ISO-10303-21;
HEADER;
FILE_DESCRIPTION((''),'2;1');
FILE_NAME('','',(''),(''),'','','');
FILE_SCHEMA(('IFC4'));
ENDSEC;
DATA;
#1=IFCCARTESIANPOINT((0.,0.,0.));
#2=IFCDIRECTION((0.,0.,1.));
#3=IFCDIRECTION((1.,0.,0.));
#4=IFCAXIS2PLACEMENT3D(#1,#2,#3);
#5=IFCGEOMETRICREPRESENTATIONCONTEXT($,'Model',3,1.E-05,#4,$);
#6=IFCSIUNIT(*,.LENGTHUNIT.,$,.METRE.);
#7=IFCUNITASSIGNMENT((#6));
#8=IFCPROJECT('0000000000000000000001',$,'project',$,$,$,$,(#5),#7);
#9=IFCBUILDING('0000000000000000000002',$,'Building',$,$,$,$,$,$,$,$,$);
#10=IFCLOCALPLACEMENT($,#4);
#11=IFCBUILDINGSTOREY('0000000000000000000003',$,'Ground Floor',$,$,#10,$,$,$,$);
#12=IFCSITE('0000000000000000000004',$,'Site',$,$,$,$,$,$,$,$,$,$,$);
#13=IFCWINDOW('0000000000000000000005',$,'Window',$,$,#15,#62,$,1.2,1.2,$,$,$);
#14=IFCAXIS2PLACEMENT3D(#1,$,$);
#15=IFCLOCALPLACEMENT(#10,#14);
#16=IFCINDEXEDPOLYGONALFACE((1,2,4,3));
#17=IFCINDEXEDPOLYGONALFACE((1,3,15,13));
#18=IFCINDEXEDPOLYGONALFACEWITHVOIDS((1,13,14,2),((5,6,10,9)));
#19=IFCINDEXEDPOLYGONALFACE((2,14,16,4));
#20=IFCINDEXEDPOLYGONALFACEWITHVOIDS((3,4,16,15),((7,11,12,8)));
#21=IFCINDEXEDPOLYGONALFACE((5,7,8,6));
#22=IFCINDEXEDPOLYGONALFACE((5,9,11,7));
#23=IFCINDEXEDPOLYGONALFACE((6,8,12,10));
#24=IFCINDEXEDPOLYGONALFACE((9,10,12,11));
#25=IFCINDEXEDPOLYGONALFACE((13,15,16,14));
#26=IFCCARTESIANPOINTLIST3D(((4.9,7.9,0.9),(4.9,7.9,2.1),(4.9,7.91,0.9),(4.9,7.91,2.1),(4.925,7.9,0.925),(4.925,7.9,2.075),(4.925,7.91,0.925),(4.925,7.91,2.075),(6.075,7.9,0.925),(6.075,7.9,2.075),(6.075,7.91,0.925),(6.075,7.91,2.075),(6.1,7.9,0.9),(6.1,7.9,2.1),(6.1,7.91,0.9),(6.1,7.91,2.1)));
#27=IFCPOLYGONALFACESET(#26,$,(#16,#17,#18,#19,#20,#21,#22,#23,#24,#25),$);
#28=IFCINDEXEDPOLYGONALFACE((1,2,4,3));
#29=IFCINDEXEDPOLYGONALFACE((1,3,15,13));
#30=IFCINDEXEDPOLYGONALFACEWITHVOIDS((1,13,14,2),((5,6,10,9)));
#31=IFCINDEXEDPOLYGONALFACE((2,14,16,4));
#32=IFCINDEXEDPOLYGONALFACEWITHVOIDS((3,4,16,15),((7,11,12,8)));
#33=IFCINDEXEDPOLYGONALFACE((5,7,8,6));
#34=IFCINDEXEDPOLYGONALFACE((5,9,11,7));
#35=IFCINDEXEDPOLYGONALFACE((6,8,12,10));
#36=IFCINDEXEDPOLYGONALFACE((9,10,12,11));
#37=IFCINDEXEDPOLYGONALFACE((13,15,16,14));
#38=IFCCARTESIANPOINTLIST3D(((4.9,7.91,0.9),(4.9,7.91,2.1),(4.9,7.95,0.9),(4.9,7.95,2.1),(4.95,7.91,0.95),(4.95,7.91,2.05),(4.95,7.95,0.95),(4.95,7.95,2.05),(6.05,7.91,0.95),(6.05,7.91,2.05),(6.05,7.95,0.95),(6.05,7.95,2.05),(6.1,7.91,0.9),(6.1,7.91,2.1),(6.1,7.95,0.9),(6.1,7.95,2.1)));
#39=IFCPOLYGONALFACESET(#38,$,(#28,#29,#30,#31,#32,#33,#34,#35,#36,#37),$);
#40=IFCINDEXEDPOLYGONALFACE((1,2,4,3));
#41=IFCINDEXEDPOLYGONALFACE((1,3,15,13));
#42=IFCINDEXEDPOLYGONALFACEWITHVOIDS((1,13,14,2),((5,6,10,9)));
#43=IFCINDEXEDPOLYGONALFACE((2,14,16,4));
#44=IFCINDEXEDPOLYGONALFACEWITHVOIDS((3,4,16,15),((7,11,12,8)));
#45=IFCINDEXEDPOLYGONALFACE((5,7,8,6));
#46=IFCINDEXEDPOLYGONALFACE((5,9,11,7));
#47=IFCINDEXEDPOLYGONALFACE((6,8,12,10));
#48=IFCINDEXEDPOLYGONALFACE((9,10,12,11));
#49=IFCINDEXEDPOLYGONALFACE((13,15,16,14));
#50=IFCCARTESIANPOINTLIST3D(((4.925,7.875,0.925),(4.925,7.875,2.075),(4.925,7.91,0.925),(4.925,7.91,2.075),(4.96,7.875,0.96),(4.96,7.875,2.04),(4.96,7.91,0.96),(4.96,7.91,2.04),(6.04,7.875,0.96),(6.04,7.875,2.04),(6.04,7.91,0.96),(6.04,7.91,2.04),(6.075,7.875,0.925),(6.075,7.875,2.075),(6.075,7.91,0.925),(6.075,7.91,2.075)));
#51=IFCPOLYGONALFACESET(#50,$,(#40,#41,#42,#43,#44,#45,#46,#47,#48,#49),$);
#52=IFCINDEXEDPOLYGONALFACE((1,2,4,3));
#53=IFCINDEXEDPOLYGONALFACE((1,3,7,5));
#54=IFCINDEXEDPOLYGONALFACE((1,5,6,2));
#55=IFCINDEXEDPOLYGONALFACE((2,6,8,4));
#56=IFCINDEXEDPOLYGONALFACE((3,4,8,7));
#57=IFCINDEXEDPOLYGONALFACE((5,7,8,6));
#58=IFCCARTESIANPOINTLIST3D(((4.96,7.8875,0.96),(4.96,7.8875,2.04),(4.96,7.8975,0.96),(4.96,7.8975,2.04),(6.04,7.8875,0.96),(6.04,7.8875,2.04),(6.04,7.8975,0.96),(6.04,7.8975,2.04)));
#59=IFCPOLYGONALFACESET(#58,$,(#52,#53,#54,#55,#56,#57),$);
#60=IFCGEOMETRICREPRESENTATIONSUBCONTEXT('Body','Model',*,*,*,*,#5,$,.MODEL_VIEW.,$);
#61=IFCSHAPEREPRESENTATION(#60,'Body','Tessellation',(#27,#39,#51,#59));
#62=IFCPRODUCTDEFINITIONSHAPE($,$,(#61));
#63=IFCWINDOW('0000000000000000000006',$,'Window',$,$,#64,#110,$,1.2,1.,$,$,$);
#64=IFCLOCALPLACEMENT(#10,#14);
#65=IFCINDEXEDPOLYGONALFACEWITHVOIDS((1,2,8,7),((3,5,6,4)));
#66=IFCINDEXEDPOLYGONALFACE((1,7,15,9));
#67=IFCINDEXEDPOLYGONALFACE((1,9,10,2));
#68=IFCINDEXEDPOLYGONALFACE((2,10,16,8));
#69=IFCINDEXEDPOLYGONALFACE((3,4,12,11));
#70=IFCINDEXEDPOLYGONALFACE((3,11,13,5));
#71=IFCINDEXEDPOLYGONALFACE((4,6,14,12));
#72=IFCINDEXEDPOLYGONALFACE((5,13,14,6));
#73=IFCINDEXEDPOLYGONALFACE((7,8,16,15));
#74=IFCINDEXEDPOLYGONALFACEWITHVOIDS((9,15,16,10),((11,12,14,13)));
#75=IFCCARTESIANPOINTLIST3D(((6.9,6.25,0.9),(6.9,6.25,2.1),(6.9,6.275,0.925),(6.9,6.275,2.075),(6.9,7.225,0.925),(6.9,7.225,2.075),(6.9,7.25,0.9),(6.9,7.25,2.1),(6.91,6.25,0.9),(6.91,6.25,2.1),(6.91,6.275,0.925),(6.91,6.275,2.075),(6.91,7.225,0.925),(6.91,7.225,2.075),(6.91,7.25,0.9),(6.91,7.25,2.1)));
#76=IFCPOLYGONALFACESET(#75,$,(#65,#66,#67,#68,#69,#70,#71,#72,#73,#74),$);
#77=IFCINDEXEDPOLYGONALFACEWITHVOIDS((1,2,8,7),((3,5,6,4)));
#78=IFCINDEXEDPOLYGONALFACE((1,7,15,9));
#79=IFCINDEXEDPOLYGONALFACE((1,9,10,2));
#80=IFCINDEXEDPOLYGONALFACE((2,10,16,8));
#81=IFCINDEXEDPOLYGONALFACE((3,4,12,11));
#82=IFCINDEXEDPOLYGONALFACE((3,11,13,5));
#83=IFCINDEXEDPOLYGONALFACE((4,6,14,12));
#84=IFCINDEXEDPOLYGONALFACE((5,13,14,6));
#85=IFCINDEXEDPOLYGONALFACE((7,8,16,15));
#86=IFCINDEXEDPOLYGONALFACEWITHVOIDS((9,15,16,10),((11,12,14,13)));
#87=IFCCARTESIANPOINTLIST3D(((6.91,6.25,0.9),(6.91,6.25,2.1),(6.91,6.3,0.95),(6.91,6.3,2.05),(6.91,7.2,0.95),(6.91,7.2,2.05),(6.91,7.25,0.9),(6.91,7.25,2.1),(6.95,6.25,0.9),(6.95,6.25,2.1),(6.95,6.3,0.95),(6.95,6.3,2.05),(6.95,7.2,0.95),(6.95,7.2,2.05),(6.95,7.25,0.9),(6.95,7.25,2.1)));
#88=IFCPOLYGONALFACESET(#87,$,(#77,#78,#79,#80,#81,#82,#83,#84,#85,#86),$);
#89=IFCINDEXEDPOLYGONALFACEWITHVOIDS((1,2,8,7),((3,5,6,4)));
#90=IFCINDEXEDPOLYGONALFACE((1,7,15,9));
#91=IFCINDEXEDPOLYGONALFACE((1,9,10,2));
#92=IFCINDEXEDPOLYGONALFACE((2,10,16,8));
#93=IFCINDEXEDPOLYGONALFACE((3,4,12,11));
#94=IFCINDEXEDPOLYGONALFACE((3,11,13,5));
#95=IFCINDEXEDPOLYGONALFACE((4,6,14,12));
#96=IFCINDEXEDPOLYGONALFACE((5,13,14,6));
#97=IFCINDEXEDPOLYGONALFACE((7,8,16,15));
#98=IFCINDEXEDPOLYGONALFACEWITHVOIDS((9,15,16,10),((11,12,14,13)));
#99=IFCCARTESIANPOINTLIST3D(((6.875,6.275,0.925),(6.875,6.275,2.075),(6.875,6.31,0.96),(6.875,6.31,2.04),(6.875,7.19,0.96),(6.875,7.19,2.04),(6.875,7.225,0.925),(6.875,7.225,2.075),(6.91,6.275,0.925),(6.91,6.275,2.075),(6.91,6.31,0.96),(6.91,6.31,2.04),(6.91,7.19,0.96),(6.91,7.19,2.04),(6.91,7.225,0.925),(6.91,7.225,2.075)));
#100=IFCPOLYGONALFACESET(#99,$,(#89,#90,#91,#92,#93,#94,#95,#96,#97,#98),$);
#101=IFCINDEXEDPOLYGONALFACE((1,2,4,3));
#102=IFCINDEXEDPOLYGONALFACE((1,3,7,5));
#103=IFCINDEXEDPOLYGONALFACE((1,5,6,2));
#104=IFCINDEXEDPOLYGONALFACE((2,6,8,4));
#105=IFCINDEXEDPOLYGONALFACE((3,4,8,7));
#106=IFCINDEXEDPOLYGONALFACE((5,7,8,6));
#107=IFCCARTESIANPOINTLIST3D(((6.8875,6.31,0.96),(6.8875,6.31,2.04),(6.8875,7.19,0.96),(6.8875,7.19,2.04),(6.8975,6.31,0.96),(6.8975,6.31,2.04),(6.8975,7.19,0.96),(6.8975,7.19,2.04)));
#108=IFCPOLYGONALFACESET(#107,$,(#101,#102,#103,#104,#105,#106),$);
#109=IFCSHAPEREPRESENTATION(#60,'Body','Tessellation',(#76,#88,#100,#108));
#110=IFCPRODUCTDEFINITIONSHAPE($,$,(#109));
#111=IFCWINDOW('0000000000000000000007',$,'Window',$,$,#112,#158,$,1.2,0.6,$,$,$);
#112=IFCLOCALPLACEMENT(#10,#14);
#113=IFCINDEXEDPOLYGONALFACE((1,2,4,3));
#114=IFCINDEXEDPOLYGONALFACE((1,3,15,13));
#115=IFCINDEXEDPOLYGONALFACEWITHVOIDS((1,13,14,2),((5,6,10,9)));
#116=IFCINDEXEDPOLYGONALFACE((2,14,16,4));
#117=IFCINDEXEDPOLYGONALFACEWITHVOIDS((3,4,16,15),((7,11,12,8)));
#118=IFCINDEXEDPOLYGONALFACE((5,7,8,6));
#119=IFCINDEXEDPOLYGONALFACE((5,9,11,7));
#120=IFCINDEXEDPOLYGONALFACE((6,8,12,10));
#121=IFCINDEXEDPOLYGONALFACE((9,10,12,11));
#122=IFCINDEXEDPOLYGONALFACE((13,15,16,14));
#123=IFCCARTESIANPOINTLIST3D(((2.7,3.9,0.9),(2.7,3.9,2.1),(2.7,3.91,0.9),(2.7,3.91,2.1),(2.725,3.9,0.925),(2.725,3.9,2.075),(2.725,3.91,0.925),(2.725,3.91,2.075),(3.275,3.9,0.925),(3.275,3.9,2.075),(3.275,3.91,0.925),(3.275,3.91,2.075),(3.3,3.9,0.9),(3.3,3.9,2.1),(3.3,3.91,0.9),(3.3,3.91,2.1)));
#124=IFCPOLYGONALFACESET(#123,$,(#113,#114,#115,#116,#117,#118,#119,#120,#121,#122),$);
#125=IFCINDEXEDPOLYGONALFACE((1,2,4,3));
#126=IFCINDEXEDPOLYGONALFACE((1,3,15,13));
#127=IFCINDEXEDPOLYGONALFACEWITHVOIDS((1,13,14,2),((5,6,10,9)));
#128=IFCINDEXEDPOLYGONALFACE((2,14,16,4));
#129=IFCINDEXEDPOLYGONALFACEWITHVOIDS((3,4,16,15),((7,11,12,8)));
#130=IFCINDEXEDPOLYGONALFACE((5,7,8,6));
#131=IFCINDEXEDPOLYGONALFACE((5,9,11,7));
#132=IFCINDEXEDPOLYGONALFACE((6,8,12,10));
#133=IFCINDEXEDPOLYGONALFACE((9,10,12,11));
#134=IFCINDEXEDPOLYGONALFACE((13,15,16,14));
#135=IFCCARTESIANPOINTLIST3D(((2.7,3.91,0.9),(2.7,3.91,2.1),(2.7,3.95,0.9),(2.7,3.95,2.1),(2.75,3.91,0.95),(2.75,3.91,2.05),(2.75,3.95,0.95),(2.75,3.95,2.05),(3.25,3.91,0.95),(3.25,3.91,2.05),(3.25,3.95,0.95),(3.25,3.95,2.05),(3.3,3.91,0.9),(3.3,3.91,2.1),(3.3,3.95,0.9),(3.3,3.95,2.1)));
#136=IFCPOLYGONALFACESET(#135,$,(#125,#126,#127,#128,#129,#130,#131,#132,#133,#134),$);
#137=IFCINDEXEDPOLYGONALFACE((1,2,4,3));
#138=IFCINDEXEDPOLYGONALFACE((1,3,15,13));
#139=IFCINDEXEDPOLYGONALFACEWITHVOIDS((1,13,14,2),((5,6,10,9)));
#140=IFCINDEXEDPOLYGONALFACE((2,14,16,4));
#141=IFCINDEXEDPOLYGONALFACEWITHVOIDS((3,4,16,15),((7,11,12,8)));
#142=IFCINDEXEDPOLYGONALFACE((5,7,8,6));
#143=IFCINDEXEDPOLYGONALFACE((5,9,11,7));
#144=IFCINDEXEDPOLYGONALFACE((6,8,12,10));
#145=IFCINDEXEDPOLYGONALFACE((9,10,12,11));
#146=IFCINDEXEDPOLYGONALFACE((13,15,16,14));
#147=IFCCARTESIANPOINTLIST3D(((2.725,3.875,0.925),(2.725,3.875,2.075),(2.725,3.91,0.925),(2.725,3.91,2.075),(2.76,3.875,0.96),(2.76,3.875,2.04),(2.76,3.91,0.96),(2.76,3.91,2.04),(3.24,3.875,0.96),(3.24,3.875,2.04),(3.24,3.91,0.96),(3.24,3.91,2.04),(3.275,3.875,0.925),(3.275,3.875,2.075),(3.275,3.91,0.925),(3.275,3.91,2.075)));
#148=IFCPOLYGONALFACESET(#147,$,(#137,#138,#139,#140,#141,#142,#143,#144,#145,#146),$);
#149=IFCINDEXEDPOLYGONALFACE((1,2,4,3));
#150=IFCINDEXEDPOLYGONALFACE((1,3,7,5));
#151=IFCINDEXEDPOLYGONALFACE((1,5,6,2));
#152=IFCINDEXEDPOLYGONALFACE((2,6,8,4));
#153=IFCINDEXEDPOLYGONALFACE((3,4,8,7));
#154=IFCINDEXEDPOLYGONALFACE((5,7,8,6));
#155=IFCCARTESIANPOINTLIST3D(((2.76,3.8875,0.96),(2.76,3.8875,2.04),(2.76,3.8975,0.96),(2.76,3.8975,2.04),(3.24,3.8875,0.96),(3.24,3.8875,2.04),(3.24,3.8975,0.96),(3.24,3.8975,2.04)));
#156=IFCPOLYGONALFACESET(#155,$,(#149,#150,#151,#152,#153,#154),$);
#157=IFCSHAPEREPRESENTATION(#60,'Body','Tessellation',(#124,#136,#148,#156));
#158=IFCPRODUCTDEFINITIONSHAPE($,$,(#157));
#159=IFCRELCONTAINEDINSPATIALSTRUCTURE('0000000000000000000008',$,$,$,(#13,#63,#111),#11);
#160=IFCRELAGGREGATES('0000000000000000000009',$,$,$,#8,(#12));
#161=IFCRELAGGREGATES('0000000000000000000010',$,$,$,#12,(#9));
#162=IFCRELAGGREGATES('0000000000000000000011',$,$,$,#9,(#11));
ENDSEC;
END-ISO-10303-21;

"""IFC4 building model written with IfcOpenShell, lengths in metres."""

from ifc_helpers import new_model, si_unit, frame, origin_with_axes, place, context, subcontext, project, spatial, line, indexed_curve, outline, extrude, element, save


model = new_model("IFC4")

# Units and contexts
model_context = context("Model", 3, precision=1e-05, world=origin_with_axes())
body_context = subcontext(model_context, "Body", "Model", "MODEL_VIEW")
ifc_project = project(units=[si_unit("LENGTHUNIT", "METRE")], contexts=[model_context])

# Site, building, storey
site = spatial("IfcSite", under=ifc_project, Name="Site")
building = spatial("IfcBuilding", under=site, Name="Building")
storey_placement = place(None, origin_with_axes())
storey = spatial("IfcBuildingStorey", under=building, at=storey_placement, Name="Ground Floor")

# Windows
window_1_placement = place(storey_placement, frame((6.1, 8.0, 0.9), z_axis=(0.0, 0.0, 1.0), x_axis=(-1.0, 0.0, 0.0)))
element("IfcWindow", 1, at=window_1_placement, inside=storey, Name="Window", OverallHeight=1.2, OverallWidth=1.2, context=body_context, shape_type="SweptSolid", body=[
    extrude(outline(indexed_curve([(0.0, 0.0), (1.2, 0.0), (1.2, 1.2), (0.0, 1.2)], segments=[line(1, 2, 3, 4, 1)]), holes=[indexed_curve([(0.025, 0.025), (1.175, 0.025), (1.175, 1.175), (0.025, 1.175)], segments=[line(1, 2, 3, 4, 1)])]), frame((0.0, 0.09, 0.0), z_axis=(0.0, -1.0, 0.0), x_axis=(1.0, 0.0, 0.0)), (0.0, 0.0, -1.0), 0.01),
    extrude(outline(indexed_curve([(0.0, 0.0), (1.2, 0.0), (1.2, 1.2), (0.0, 1.2)], segments=[line(1, 2, 3, 4, 1)]), holes=[indexed_curve([(0.05, 0.05), (1.15, 0.05), (1.15, 1.15), (0.05, 1.15)], segments=[line(1, 2, 3, 4, 1)])]), frame((0.0, 0.05, 0.0), z_axis=(0.0, -1.0, 0.0), x_axis=(1.0, 0.0, 0.0)), (0.0, 0.0, -1.0), 0.04),
    extrude(outline(indexed_curve([(0.0, 0.0), (1.15, 0.0), (1.15, 1.15), (0.0, 1.15)], segments=[line(1, 2, 3, 4, 1)]), holes=[indexed_curve([(0.035, 0.035), (1.115, 0.035), (1.115, 1.115), (0.035, 1.115)], segments=[line(1, 2, 3, 4, 1)])]), frame((0.025, 0.09, 0.025), z_axis=(0.0, -1.0, 0.0), x_axis=(1.0, 0.0, 0.0)), (0.0, 0.0, -1.0), 0.035),
    extrude(outline(indexed_curve([(0.035, 0.035), (1.115, 0.035), (1.115, 1.115), (0.035, 1.115)], segments=[line(1, 2, 3, 4, 1)])), frame((0.025, 0.1025, 0.025), z_axis=(0.0, -1.0, 0.0), x_axis=(1.0, 0.0, 0.0)), (0.0, 0.0, -1.0), 0.01),
])
window_2_placement = place(storey_placement, frame((7.0, 6.25, 0.9), z_axis=(0.0, 0.0, 1.0), x_axis=(0.0, 1.0, 0.0)))
element("IfcWindow", 2, at=window_2_placement, inside=storey, Name="Window", OverallHeight=1.2, OverallWidth=1.0, context=body_context, shape_type="SweptSolid", body=[
    extrude(outline(indexed_curve([(0.0, 0.0), (1.0, 0.0), (1.0, 1.2), (0.0, 1.2)], segments=[line(1, 2, 3, 4, 1)]), holes=[indexed_curve([(0.025, 0.025), (0.975, 0.025), (0.975, 1.175), (0.025, 1.175)], segments=[line(1, 2, 3, 4, 1)])]), frame((0.0, 0.09, 0.0), z_axis=(0.0, -1.0, 0.0), x_axis=(1.0, 0.0, 0.0)), (0.0, 0.0, -1.0), 0.01),
    extrude(outline(indexed_curve([(0.0, 0.0), (1.0, 0.0), (1.0, 1.2), (0.0, 1.2)], segments=[line(1, 2, 3, 4, 1)]), holes=[indexed_curve([(0.05, 0.05), (0.95, 0.05), (0.95, 1.15), (0.05, 1.15)], segments=[line(1, 2, 3, 4, 1)])]), frame((0.0, 0.05, 0.0), z_axis=(0.0, -1.0, 0.0), x_axis=(1.0, 0.0, 0.0)), (0.0, 0.0, -1.0), 0.04),
    extrude(outline(indexed_curve([(0.0, 0.0), (0.95, 0.0), (0.95, 1.15), (0.0, 1.15)], segments=[line(1, 2, 3, 4, 1)]), holes=[indexed_curve([(0.035, 0.035), (0.915, 0.035), (0.915, 1.115), (0.035, 1.115)], segments=[line(1, 2, 3, 4, 1)])]), frame((0.025, 0.09, 0.025), z_axis=(0.0, -1.0, 0.0), x_axis=(1.0, 0.0, 0.0)), (0.0, 0.0, -1.0), 0.035),
    extrude(outline(indexed_curve([(0.035, 0.035), (0.915, 0.035), (0.915, 1.115), (0.035, 1.115)], segments=[line(1, 2, 3, 4, 1)])), frame((0.025, 0.1025, 0.025), z_axis=(0.0, -1.0, 0.0), x_axis=(1.0, 0.0, 0.0)), (0.0, 0.0, -1.0), 0.01),
])
window_3_placement = place(storey_placement, frame((3.3, 4.0, 0.9), z_axis=(0.0, 0.0, 1.0), x_axis=(-1.0, 0.0, 0.0)))
element("IfcWindow", 3, at=window_3_placement, inside=storey, Name="Window", OverallHeight=1.2, OverallWidth=0.6, context=body_context, shape_type="SweptSolid", body=[
    extrude(outline(indexed_curve([(0.0, 0.0), (0.6, 0.0), (0.6, 1.2), (0.0, 1.2)], segments=[line(1, 2, 3, 4, 1)]), holes=[indexed_curve([(0.025, 0.025), (0.575, 0.025), (0.575, 1.175), (0.025, 1.175)], segments=[line(1, 2, 3, 4, 1)])]), frame((0.0, 0.09, 0.0), z_axis=(0.0, -1.0, 0.0), x_axis=(1.0, 0.0, 0.0)), (0.0, 0.0, -1.0), 0.01),
    extrude(outline(indexed_curve([(0.0, 0.0), (0.6, 0.0), (0.6, 1.2), (0.0, 1.2)], segments=[line(1, 2, 3, 4, 1)]), holes=[indexed_curve([(0.05, 0.05), (0.55, 0.05), (0.55, 1.15), (0.05, 1.15)], segments=[line(1, 2, 3, 4, 1)])]), frame((0.0, 0.05, 0.0), z_axis=(0.0, -1.0, 0.0), x_axis=(1.0, 0.0, 0.0)), (0.0, 0.0, -1.0), 0.04),
    extrude(outline(indexed_curve([(0.0, 0.0), (0.55, 0.0), (0.55, 1.15), (0.0, 1.15)], segments=[line(1, 2, 3, 4, 1)]), holes=[indexed_curve([(0.035, 0.035), (0.515, 0.035), (0.515, 1.115), (0.035, 1.115)], segments=[line(1, 2, 3, 4, 1)])]), frame((0.025, 0.09, 0.025), z_axis=(0.0, -1.0, 0.0), x_axis=(1.0, 0.0, 0.0)), (0.0, 0.0, -1.0), 0.035),
    extrude(outline(indexed_curve([(0.035, 0.035), (0.515, 0.035), (0.515, 1.115), (0.035, 1.115)], segments=[line(1, 2, 3, 4, 1)])), frame((0.025, 0.1025, 0.025), z_axis=(0.0, -1.0, 0.0), x_axis=(1.0, 0.0, 0.0)), (0.0, 0.0, -1.0), 0.01),
])

save(model, "model.ifc")
